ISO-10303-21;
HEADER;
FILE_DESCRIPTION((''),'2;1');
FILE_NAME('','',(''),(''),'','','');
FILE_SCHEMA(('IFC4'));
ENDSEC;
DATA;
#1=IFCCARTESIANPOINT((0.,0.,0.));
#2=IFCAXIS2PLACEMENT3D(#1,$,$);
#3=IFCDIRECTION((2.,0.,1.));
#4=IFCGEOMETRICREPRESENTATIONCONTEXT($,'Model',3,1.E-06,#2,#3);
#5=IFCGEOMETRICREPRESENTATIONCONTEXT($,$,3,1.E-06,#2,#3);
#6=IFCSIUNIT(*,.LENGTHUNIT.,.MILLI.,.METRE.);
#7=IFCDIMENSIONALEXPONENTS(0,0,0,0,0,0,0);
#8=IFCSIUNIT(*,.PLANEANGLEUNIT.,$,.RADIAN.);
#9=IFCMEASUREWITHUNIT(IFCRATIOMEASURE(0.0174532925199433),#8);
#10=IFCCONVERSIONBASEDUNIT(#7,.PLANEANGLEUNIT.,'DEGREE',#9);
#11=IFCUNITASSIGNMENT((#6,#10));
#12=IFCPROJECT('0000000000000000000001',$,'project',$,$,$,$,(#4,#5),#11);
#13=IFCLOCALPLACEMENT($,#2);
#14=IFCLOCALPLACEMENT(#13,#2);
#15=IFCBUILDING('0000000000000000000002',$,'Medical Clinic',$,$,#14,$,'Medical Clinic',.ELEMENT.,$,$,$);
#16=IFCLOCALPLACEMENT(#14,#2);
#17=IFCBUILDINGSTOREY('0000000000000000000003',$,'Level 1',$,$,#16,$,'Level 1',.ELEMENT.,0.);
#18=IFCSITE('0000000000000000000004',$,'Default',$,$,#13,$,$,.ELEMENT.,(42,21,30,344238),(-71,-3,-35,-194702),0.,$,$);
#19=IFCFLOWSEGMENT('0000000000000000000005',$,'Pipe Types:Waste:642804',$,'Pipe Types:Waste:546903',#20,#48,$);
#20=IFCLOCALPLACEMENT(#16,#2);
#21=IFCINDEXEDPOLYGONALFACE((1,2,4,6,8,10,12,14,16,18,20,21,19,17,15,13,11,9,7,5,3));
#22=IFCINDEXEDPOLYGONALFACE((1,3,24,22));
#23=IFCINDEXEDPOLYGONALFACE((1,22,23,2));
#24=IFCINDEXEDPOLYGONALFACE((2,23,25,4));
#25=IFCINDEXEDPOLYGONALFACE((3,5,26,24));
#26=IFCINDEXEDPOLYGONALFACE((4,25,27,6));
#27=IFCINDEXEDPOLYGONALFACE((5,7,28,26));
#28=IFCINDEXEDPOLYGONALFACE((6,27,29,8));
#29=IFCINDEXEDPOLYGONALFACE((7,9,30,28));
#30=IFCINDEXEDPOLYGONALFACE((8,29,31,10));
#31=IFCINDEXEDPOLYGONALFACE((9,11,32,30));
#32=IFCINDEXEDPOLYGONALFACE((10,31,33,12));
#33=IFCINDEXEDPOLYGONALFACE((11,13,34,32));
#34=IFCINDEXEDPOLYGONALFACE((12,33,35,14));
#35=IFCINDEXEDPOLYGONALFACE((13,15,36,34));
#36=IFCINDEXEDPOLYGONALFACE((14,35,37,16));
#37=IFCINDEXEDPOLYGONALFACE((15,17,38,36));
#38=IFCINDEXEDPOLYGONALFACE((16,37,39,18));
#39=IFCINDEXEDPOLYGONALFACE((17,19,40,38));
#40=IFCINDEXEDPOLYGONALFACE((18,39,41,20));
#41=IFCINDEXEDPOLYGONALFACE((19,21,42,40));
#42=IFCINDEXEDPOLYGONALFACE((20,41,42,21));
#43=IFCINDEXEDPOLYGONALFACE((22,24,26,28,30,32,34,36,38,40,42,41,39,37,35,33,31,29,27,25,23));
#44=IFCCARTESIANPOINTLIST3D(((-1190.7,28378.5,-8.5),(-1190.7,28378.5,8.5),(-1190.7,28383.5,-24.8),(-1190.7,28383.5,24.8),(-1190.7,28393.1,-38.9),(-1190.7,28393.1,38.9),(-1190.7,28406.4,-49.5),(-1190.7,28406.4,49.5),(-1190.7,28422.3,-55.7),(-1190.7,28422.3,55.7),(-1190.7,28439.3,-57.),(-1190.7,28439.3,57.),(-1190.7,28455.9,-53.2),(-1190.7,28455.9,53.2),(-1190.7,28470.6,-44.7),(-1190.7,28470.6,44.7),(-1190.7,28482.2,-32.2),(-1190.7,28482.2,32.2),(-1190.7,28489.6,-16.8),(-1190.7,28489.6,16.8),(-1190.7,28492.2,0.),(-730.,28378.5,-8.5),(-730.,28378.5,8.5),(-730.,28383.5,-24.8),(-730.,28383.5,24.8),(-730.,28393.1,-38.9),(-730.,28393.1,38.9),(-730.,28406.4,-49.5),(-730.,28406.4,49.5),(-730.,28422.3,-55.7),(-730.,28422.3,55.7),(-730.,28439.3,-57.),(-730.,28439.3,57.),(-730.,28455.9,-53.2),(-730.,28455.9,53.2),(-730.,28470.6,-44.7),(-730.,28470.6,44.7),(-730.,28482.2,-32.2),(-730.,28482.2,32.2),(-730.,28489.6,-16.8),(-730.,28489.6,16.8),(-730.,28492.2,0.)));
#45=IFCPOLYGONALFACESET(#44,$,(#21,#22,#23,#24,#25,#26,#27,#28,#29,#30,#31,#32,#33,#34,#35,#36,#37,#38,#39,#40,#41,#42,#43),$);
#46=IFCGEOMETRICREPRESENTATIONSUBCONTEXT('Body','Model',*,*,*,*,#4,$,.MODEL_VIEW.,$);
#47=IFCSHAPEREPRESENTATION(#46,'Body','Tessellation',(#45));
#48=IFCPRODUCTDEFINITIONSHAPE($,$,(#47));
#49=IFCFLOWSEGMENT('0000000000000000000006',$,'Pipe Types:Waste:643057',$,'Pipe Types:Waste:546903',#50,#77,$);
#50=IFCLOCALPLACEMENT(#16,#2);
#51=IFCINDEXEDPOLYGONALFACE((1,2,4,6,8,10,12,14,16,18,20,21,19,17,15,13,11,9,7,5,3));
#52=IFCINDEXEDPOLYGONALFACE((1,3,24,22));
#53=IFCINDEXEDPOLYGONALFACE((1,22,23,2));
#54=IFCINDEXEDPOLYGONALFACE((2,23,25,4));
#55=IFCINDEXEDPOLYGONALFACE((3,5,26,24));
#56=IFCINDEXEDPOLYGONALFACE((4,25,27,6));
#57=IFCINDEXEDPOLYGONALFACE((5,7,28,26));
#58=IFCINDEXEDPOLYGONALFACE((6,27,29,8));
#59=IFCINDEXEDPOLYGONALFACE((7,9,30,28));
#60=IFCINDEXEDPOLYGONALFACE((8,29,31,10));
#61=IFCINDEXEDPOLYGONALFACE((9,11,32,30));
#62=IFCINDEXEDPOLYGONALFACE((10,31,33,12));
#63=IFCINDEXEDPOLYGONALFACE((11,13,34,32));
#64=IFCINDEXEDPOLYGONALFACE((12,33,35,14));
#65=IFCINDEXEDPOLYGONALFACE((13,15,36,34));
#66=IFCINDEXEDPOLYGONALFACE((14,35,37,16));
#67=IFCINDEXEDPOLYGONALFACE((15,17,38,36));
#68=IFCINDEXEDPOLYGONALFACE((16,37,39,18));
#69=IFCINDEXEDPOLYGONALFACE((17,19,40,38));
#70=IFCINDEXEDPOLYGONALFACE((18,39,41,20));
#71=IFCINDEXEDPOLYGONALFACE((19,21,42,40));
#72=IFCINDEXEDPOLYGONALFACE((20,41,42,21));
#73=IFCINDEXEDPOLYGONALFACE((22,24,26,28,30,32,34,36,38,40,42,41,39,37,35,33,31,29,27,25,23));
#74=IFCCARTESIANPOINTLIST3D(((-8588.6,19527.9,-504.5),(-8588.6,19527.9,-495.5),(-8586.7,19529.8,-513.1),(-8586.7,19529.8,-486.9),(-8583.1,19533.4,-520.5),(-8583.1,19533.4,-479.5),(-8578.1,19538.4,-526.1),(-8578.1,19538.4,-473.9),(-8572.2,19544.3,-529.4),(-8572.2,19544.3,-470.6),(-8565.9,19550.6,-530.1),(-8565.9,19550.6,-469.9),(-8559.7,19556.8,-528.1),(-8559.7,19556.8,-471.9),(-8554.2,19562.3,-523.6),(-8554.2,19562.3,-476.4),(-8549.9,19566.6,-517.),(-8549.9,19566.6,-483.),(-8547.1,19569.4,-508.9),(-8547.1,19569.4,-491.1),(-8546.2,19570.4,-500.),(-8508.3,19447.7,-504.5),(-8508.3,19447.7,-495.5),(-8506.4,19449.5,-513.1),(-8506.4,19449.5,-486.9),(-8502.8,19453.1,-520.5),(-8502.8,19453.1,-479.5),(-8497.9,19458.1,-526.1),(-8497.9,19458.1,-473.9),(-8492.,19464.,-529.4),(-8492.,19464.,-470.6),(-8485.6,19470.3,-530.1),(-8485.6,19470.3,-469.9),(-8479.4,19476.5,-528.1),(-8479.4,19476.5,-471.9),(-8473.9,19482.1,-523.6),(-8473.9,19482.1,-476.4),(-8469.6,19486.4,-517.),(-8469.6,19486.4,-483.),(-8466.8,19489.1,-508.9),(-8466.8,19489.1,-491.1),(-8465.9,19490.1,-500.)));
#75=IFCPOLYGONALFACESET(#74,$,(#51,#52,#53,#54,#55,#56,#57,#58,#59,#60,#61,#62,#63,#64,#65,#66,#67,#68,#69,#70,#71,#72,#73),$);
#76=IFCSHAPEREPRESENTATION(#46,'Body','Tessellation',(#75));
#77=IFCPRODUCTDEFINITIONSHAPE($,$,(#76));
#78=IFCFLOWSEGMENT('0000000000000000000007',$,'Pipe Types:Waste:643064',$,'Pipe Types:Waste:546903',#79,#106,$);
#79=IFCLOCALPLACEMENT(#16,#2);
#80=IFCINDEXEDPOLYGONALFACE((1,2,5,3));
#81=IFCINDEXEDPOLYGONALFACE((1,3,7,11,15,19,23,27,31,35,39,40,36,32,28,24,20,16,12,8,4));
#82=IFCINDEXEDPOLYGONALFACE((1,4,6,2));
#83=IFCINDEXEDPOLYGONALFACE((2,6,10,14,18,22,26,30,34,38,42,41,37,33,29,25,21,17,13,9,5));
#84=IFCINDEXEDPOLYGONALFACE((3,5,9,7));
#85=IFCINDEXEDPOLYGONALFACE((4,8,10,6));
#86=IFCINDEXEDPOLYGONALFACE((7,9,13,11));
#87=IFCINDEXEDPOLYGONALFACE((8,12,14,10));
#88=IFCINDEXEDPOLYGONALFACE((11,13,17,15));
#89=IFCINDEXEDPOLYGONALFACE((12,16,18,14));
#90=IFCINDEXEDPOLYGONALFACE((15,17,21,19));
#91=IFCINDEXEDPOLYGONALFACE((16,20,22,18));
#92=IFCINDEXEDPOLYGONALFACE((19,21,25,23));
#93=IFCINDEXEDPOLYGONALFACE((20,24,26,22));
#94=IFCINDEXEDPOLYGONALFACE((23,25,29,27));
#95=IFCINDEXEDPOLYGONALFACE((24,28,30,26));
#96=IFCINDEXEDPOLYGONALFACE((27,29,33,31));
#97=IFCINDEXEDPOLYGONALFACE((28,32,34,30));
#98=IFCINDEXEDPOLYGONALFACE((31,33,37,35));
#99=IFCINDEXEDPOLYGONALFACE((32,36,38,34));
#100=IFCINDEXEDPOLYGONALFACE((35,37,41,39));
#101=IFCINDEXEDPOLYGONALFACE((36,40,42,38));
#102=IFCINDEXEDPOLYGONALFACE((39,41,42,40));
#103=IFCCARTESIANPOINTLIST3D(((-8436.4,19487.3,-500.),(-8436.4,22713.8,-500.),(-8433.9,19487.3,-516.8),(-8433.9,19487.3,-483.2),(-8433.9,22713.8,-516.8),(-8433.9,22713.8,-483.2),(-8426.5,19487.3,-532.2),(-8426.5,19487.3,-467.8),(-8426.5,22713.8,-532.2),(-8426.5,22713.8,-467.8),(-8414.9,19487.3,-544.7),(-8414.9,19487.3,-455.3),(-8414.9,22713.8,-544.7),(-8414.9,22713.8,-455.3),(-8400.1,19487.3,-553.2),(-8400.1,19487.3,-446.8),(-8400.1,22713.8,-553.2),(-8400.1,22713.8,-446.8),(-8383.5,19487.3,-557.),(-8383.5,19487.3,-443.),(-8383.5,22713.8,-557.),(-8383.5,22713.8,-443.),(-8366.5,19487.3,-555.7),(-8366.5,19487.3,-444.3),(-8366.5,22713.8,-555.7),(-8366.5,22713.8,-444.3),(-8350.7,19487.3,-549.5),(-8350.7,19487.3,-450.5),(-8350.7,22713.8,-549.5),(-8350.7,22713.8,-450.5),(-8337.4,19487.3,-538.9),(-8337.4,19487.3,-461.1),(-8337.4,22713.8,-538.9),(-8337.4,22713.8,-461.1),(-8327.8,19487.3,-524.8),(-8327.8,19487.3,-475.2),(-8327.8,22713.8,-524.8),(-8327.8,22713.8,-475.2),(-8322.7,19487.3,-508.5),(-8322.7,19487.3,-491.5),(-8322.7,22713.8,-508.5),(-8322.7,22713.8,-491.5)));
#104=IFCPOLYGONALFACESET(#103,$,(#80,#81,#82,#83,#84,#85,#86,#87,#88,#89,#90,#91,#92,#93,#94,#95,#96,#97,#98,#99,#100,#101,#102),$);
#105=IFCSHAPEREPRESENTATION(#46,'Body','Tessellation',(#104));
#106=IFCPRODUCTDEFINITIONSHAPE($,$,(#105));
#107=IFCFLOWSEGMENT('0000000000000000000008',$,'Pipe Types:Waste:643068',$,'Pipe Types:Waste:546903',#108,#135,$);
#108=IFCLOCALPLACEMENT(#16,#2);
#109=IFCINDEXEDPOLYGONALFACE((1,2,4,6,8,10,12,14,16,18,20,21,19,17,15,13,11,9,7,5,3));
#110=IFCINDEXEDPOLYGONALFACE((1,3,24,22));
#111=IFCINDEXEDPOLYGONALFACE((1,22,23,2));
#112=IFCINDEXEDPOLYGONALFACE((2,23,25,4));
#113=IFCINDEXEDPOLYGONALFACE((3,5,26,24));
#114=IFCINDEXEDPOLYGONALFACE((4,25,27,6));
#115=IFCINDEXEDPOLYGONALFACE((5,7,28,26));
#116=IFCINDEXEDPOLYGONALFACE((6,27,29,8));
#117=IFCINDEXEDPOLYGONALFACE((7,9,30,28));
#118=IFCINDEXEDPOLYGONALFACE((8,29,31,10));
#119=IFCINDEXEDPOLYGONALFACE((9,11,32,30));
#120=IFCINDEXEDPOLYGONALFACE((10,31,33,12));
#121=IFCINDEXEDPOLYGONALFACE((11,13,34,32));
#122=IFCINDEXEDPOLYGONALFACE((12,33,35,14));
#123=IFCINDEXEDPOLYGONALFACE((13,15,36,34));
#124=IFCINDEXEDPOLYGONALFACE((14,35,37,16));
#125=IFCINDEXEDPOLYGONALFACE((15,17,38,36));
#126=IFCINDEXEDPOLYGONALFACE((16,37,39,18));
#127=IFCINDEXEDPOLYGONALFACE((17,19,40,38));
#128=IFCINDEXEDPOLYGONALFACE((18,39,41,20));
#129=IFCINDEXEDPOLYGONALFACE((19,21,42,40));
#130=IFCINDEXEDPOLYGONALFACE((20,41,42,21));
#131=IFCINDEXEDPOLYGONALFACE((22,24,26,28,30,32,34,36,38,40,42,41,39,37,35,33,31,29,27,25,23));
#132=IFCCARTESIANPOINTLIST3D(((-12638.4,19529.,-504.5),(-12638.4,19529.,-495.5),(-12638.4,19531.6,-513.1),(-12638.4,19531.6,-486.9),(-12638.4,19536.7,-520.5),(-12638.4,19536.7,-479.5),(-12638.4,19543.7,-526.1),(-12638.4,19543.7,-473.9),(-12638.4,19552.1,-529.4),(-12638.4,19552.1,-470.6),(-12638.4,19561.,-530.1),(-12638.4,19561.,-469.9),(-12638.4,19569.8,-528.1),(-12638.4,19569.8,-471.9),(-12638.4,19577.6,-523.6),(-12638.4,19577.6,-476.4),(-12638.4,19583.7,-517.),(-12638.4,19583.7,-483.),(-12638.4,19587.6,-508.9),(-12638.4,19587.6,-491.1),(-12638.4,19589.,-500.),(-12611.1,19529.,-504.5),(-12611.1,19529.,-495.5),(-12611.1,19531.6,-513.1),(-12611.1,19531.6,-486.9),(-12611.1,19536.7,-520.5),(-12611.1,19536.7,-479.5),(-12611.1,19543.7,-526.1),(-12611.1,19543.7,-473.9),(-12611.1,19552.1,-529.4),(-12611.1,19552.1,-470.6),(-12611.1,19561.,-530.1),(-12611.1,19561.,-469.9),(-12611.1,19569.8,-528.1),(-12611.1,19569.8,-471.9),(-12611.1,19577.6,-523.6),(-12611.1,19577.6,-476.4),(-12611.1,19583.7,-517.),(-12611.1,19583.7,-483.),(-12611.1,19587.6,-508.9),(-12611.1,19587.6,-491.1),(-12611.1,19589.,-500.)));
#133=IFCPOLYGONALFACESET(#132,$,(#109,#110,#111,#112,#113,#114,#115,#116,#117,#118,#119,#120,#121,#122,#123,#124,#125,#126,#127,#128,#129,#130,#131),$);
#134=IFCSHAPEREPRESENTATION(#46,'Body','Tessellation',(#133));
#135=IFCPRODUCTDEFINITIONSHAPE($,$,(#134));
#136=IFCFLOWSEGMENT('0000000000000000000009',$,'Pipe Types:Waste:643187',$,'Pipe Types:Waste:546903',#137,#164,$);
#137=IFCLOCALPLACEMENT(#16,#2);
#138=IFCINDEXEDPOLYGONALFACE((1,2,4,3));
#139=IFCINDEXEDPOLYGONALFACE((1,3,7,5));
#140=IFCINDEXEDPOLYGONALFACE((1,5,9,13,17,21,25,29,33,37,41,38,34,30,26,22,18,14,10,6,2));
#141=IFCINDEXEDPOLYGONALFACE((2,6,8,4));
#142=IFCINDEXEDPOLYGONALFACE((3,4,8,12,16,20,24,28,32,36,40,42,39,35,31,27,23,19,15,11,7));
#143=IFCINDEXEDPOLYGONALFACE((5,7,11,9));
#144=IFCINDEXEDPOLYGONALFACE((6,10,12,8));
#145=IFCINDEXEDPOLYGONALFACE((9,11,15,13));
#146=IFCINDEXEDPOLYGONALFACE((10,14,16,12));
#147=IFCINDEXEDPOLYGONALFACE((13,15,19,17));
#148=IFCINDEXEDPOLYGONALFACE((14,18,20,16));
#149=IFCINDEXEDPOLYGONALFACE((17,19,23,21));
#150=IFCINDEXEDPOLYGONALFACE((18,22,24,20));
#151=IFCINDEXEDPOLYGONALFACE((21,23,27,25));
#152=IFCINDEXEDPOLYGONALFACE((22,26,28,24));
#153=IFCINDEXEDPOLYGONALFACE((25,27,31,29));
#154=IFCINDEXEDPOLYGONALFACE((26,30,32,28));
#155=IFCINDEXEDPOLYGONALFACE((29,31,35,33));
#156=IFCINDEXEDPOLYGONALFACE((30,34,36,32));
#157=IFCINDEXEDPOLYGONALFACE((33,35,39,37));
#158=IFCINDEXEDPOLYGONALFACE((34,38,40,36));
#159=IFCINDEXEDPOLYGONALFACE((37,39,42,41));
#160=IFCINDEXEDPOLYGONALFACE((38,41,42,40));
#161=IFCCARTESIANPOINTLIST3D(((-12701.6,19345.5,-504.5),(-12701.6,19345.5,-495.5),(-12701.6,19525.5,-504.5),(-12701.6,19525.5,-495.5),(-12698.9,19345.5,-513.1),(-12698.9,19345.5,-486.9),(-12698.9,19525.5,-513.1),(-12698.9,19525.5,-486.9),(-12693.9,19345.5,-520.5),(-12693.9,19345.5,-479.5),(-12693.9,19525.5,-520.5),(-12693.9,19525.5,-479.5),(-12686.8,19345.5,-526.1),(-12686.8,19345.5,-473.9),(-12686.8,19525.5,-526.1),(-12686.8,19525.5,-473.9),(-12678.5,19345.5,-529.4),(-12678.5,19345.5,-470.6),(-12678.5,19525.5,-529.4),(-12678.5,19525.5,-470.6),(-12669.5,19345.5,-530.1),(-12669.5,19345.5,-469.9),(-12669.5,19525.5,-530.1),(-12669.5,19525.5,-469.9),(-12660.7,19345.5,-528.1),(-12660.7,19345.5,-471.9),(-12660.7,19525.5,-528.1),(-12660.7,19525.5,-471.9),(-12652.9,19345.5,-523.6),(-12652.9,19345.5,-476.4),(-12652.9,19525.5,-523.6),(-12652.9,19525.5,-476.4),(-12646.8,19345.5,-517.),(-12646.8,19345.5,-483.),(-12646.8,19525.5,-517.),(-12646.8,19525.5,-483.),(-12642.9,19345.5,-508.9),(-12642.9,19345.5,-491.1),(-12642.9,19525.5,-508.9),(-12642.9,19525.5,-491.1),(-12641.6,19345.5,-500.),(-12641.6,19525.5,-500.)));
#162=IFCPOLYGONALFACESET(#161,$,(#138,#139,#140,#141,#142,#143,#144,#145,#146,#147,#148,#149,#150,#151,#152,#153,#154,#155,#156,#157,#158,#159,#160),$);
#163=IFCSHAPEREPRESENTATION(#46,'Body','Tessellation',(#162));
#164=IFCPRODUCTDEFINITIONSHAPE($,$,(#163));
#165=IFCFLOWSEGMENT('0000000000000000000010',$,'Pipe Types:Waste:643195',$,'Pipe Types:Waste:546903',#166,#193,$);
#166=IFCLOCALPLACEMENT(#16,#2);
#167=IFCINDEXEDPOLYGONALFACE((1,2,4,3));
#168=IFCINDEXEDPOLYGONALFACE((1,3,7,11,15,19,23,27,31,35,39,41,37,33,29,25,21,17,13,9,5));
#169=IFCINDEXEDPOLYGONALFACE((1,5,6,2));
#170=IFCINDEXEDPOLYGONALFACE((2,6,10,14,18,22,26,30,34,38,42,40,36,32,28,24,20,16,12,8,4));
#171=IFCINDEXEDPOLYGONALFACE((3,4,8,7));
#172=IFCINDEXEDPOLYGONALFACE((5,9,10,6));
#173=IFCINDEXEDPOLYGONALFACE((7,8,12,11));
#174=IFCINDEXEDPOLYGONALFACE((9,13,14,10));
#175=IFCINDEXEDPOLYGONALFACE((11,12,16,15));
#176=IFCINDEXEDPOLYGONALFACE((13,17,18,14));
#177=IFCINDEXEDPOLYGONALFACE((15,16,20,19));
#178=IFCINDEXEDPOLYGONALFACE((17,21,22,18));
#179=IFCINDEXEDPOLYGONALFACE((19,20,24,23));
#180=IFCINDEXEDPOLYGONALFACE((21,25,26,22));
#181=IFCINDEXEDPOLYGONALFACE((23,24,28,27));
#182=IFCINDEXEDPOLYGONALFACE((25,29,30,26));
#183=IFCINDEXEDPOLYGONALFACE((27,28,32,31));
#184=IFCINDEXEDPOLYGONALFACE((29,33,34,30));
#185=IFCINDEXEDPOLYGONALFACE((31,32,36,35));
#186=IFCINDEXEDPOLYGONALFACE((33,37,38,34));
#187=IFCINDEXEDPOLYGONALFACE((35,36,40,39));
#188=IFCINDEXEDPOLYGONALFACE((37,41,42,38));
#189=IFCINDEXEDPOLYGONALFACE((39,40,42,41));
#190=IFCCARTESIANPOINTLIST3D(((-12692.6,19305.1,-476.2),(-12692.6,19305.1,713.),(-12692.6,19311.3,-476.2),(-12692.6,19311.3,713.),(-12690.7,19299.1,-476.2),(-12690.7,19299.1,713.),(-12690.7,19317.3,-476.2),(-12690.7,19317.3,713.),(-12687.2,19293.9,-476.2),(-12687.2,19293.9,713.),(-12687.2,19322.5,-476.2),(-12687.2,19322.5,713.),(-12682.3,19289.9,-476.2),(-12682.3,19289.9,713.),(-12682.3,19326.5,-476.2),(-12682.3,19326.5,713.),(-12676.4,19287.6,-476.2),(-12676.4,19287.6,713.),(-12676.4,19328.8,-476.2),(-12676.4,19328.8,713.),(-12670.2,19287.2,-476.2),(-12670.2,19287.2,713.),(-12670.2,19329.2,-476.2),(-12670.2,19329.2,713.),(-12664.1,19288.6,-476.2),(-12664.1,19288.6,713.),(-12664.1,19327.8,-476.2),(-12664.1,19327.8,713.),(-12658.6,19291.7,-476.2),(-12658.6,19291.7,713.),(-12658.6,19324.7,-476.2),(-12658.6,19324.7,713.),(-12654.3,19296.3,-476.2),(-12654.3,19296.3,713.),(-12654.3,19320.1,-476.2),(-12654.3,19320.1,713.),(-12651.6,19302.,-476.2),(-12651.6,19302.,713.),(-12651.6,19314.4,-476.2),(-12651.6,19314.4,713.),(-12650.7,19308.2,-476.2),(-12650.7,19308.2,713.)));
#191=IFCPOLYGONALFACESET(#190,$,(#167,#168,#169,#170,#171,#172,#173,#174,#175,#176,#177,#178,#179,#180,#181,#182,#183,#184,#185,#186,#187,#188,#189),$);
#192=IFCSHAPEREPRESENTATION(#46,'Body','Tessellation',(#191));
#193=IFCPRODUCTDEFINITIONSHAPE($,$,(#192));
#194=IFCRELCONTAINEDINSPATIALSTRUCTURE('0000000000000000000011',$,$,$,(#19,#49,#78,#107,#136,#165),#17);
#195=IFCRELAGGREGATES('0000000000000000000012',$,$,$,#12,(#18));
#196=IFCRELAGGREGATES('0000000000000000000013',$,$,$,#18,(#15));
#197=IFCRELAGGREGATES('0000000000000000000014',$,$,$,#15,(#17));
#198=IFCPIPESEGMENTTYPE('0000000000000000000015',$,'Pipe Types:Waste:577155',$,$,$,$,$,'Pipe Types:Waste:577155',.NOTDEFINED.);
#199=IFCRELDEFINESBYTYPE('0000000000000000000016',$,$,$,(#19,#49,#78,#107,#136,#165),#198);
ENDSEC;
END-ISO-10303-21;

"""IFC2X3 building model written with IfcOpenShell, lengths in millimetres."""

from ifc_helpers import new_model, entity, si_unit, converted_unit, direction, frame, frame_2d, origin, origin_2d_with_axis, place, context, subcontext, project, spatial, circle, extrude, type_object, element, save


model = new_model("IFC2X3")

# Units and contexts
model_context = context("Model", 3, precision=1e-06, world=origin(), true_north=direction((2.0, 0.0, 1.0)))
context_of_model = context(None, 3, precision=1e-06, world=origin(), true_north=direction((2.0, 0.0, 1.0)))
body_context = subcontext(model_context, "Body", "Model", "MODEL_VIEW")
ifc_project = project(units=[si_unit("LENGTHUNIT", "METRE", prefix="MILLI"), converted_unit("PLANEANGLEUNIT", "DEGREE", entity("IfcRatioMeasure", 0.0174532925199433), si_unit("PLANEANGLEUNIT", "RADIAN"), dimensions=[0, 0, 0, 0, 0, 0, 0])], contexts=[model_context, context_of_model])

# Site, building, storey
site_placement = place(None, origin())
site = spatial("IfcSite", under=ifc_project, at=site_placement, Name="Default", CompositionType="ELEMENT", RefLatitude=(42, 21, 30, 344238), RefLongitude=(-71, -3, -35, -194702), RefElevation=0.0)
building_placement = place(site_placement, origin())
building = spatial("IfcBuilding", under=site, at=building_placement, Name="Medical Clinic", LongName="Medical Clinic", CompositionType="ELEMENT")
storey_placement = place(building_placement, origin())
storey = spatial("IfcBuildingStorey", under=building, at=storey_placement, Name="Level 1", LongName="Level 1", CompositionType="ELEMENT", Elevation=0.0)

# Flow segments
pipe_segment_type_1 = type_object("IfcPipeSegmentType", Name="Pipe Types:Waste:577155", ElementType="Pipe Types:Waste:577155", PredefinedType="NOTDEFINED")
flow_segment_1_placement = place(storey_placement, origin())
element("IfcFlowSegment", 1, at=flow_segment_1_placement, inside=storey, type_object=pipe_segment_type_1, Name="Pipe Types:Waste:642804", ObjectType="Pipe Types:Waste:546903", context=body_context, shape_type="SweptSolid", body=[
    extrude(circle(Radius=57.1, at=frame_2d((0.0, 0.0), x_axis=(1.0, 0.0))), frame((-1190.7, 28435.0, 0.0), z_axis=(1.0, 0.0, 0.0), x_axis=(0.0, 1.0, 0.0)), (0.0, 0.0, 1.0), 460.7),
])
flow_segment_2_placement = place(storey_placement, origin())
element("IfcFlowSegment", 2, at=flow_segment_2_placement, inside=storey, type_object=pipe_segment_type_1, Name="Pipe Types:Waste:643057", ObjectType="Pipe Types:Waste:546903", context=body_context, shape_type="SweptSolid", body=[
    extrude(circle(Radius=30.2, at=frame_2d((0.0, 0.0), x_axis=(1.0, 0.0))), frame((-8487.2, 19468.8, -500.0), z_axis=(-0.707107, 0.707107, 0.0), x_axis=(0.707107, 0.707107, 0.0)), (0.0, 0.0, 1.0), 113.5),
])
flow_segment_3_placement = place(storey_placement, origin())
element("IfcFlowSegment", 3, at=flow_segment_3_placement, inside=storey, type_object=pipe_segment_type_1, Name="Pipe Types:Waste:643064", ObjectType="Pipe Types:Waste:546903", context=body_context, shape_type="SweptSolid", body=[
    extrude(circle(Radius=57.1, at=frame_2d((0.0, 0.0), x_axis=(1.0, 0.0))), frame((-8379.3, 19487.3, -500.0), z_axis=(0.0, 1.0, 0.0), x_axis=(-1.0, 0.0, 0.0)), (0.0, 0.0, 1.0), 3226.5),
])
flow_segment_4_placement = place(storey_placement, origin())
element("IfcFlowSegment", 4, at=flow_segment_4_placement, inside=storey, type_object=pipe_segment_type_1, Name="Pipe Types:Waste:643068", ObjectType="Pipe Types:Waste:546903", context=body_context, shape_type="SweptSolid", body=[
    extrude(circle(Radius=30.2, at=origin_2d_with_axis()), frame((-12638.4, 19558.8, -500.0), z_axis=(1.0, 0.0, 0.0), x_axis=(0.0, 1.0, 0.0)), (0.0, 0.0, 1.0), 27.3),
])
flow_segment_5_placement = place(storey_placement, origin())
element("IfcFlowSegment", 5, at=flow_segment_5_placement, inside=storey, type_object=pipe_segment_type_1, Name="Pipe Types:Waste:643187", ObjectType="Pipe Types:Waste:546903", context=body_context, shape_type="SweptSolid", body=[
    extrude(circle(Radius=30.2, at=frame_2d((0.0, 0.0), x_axis=(1.0, 0.0))), frame((-12671.8, 19345.5, -500.0), z_axis=(0.0, 1.0, 0.0), x_axis=(1.0, 0.0, 0.0)), (0.0, 0.0, 1.0), 179.9),
])
flow_segment_6_placement = place(storey_placement, origin())
element("IfcFlowSegment", 6, at=flow_segment_6_placement, inside=storey, type_object=pipe_segment_type_1, Name="Pipe Types:Waste:643195", ObjectType="Pipe Types:Waste:546903", context=body_context, shape_type="SweptSolid", body=[
    extrude(circle(Radius=21.1, at=frame_2d((0.0, 0.0), x_axis=(1.0, 0.0))), frame((-12671.8, 19308.2, -476.2)), (0.0, 0.0, 1.0), 1189.2),
])

save(model, "model.ifc")
